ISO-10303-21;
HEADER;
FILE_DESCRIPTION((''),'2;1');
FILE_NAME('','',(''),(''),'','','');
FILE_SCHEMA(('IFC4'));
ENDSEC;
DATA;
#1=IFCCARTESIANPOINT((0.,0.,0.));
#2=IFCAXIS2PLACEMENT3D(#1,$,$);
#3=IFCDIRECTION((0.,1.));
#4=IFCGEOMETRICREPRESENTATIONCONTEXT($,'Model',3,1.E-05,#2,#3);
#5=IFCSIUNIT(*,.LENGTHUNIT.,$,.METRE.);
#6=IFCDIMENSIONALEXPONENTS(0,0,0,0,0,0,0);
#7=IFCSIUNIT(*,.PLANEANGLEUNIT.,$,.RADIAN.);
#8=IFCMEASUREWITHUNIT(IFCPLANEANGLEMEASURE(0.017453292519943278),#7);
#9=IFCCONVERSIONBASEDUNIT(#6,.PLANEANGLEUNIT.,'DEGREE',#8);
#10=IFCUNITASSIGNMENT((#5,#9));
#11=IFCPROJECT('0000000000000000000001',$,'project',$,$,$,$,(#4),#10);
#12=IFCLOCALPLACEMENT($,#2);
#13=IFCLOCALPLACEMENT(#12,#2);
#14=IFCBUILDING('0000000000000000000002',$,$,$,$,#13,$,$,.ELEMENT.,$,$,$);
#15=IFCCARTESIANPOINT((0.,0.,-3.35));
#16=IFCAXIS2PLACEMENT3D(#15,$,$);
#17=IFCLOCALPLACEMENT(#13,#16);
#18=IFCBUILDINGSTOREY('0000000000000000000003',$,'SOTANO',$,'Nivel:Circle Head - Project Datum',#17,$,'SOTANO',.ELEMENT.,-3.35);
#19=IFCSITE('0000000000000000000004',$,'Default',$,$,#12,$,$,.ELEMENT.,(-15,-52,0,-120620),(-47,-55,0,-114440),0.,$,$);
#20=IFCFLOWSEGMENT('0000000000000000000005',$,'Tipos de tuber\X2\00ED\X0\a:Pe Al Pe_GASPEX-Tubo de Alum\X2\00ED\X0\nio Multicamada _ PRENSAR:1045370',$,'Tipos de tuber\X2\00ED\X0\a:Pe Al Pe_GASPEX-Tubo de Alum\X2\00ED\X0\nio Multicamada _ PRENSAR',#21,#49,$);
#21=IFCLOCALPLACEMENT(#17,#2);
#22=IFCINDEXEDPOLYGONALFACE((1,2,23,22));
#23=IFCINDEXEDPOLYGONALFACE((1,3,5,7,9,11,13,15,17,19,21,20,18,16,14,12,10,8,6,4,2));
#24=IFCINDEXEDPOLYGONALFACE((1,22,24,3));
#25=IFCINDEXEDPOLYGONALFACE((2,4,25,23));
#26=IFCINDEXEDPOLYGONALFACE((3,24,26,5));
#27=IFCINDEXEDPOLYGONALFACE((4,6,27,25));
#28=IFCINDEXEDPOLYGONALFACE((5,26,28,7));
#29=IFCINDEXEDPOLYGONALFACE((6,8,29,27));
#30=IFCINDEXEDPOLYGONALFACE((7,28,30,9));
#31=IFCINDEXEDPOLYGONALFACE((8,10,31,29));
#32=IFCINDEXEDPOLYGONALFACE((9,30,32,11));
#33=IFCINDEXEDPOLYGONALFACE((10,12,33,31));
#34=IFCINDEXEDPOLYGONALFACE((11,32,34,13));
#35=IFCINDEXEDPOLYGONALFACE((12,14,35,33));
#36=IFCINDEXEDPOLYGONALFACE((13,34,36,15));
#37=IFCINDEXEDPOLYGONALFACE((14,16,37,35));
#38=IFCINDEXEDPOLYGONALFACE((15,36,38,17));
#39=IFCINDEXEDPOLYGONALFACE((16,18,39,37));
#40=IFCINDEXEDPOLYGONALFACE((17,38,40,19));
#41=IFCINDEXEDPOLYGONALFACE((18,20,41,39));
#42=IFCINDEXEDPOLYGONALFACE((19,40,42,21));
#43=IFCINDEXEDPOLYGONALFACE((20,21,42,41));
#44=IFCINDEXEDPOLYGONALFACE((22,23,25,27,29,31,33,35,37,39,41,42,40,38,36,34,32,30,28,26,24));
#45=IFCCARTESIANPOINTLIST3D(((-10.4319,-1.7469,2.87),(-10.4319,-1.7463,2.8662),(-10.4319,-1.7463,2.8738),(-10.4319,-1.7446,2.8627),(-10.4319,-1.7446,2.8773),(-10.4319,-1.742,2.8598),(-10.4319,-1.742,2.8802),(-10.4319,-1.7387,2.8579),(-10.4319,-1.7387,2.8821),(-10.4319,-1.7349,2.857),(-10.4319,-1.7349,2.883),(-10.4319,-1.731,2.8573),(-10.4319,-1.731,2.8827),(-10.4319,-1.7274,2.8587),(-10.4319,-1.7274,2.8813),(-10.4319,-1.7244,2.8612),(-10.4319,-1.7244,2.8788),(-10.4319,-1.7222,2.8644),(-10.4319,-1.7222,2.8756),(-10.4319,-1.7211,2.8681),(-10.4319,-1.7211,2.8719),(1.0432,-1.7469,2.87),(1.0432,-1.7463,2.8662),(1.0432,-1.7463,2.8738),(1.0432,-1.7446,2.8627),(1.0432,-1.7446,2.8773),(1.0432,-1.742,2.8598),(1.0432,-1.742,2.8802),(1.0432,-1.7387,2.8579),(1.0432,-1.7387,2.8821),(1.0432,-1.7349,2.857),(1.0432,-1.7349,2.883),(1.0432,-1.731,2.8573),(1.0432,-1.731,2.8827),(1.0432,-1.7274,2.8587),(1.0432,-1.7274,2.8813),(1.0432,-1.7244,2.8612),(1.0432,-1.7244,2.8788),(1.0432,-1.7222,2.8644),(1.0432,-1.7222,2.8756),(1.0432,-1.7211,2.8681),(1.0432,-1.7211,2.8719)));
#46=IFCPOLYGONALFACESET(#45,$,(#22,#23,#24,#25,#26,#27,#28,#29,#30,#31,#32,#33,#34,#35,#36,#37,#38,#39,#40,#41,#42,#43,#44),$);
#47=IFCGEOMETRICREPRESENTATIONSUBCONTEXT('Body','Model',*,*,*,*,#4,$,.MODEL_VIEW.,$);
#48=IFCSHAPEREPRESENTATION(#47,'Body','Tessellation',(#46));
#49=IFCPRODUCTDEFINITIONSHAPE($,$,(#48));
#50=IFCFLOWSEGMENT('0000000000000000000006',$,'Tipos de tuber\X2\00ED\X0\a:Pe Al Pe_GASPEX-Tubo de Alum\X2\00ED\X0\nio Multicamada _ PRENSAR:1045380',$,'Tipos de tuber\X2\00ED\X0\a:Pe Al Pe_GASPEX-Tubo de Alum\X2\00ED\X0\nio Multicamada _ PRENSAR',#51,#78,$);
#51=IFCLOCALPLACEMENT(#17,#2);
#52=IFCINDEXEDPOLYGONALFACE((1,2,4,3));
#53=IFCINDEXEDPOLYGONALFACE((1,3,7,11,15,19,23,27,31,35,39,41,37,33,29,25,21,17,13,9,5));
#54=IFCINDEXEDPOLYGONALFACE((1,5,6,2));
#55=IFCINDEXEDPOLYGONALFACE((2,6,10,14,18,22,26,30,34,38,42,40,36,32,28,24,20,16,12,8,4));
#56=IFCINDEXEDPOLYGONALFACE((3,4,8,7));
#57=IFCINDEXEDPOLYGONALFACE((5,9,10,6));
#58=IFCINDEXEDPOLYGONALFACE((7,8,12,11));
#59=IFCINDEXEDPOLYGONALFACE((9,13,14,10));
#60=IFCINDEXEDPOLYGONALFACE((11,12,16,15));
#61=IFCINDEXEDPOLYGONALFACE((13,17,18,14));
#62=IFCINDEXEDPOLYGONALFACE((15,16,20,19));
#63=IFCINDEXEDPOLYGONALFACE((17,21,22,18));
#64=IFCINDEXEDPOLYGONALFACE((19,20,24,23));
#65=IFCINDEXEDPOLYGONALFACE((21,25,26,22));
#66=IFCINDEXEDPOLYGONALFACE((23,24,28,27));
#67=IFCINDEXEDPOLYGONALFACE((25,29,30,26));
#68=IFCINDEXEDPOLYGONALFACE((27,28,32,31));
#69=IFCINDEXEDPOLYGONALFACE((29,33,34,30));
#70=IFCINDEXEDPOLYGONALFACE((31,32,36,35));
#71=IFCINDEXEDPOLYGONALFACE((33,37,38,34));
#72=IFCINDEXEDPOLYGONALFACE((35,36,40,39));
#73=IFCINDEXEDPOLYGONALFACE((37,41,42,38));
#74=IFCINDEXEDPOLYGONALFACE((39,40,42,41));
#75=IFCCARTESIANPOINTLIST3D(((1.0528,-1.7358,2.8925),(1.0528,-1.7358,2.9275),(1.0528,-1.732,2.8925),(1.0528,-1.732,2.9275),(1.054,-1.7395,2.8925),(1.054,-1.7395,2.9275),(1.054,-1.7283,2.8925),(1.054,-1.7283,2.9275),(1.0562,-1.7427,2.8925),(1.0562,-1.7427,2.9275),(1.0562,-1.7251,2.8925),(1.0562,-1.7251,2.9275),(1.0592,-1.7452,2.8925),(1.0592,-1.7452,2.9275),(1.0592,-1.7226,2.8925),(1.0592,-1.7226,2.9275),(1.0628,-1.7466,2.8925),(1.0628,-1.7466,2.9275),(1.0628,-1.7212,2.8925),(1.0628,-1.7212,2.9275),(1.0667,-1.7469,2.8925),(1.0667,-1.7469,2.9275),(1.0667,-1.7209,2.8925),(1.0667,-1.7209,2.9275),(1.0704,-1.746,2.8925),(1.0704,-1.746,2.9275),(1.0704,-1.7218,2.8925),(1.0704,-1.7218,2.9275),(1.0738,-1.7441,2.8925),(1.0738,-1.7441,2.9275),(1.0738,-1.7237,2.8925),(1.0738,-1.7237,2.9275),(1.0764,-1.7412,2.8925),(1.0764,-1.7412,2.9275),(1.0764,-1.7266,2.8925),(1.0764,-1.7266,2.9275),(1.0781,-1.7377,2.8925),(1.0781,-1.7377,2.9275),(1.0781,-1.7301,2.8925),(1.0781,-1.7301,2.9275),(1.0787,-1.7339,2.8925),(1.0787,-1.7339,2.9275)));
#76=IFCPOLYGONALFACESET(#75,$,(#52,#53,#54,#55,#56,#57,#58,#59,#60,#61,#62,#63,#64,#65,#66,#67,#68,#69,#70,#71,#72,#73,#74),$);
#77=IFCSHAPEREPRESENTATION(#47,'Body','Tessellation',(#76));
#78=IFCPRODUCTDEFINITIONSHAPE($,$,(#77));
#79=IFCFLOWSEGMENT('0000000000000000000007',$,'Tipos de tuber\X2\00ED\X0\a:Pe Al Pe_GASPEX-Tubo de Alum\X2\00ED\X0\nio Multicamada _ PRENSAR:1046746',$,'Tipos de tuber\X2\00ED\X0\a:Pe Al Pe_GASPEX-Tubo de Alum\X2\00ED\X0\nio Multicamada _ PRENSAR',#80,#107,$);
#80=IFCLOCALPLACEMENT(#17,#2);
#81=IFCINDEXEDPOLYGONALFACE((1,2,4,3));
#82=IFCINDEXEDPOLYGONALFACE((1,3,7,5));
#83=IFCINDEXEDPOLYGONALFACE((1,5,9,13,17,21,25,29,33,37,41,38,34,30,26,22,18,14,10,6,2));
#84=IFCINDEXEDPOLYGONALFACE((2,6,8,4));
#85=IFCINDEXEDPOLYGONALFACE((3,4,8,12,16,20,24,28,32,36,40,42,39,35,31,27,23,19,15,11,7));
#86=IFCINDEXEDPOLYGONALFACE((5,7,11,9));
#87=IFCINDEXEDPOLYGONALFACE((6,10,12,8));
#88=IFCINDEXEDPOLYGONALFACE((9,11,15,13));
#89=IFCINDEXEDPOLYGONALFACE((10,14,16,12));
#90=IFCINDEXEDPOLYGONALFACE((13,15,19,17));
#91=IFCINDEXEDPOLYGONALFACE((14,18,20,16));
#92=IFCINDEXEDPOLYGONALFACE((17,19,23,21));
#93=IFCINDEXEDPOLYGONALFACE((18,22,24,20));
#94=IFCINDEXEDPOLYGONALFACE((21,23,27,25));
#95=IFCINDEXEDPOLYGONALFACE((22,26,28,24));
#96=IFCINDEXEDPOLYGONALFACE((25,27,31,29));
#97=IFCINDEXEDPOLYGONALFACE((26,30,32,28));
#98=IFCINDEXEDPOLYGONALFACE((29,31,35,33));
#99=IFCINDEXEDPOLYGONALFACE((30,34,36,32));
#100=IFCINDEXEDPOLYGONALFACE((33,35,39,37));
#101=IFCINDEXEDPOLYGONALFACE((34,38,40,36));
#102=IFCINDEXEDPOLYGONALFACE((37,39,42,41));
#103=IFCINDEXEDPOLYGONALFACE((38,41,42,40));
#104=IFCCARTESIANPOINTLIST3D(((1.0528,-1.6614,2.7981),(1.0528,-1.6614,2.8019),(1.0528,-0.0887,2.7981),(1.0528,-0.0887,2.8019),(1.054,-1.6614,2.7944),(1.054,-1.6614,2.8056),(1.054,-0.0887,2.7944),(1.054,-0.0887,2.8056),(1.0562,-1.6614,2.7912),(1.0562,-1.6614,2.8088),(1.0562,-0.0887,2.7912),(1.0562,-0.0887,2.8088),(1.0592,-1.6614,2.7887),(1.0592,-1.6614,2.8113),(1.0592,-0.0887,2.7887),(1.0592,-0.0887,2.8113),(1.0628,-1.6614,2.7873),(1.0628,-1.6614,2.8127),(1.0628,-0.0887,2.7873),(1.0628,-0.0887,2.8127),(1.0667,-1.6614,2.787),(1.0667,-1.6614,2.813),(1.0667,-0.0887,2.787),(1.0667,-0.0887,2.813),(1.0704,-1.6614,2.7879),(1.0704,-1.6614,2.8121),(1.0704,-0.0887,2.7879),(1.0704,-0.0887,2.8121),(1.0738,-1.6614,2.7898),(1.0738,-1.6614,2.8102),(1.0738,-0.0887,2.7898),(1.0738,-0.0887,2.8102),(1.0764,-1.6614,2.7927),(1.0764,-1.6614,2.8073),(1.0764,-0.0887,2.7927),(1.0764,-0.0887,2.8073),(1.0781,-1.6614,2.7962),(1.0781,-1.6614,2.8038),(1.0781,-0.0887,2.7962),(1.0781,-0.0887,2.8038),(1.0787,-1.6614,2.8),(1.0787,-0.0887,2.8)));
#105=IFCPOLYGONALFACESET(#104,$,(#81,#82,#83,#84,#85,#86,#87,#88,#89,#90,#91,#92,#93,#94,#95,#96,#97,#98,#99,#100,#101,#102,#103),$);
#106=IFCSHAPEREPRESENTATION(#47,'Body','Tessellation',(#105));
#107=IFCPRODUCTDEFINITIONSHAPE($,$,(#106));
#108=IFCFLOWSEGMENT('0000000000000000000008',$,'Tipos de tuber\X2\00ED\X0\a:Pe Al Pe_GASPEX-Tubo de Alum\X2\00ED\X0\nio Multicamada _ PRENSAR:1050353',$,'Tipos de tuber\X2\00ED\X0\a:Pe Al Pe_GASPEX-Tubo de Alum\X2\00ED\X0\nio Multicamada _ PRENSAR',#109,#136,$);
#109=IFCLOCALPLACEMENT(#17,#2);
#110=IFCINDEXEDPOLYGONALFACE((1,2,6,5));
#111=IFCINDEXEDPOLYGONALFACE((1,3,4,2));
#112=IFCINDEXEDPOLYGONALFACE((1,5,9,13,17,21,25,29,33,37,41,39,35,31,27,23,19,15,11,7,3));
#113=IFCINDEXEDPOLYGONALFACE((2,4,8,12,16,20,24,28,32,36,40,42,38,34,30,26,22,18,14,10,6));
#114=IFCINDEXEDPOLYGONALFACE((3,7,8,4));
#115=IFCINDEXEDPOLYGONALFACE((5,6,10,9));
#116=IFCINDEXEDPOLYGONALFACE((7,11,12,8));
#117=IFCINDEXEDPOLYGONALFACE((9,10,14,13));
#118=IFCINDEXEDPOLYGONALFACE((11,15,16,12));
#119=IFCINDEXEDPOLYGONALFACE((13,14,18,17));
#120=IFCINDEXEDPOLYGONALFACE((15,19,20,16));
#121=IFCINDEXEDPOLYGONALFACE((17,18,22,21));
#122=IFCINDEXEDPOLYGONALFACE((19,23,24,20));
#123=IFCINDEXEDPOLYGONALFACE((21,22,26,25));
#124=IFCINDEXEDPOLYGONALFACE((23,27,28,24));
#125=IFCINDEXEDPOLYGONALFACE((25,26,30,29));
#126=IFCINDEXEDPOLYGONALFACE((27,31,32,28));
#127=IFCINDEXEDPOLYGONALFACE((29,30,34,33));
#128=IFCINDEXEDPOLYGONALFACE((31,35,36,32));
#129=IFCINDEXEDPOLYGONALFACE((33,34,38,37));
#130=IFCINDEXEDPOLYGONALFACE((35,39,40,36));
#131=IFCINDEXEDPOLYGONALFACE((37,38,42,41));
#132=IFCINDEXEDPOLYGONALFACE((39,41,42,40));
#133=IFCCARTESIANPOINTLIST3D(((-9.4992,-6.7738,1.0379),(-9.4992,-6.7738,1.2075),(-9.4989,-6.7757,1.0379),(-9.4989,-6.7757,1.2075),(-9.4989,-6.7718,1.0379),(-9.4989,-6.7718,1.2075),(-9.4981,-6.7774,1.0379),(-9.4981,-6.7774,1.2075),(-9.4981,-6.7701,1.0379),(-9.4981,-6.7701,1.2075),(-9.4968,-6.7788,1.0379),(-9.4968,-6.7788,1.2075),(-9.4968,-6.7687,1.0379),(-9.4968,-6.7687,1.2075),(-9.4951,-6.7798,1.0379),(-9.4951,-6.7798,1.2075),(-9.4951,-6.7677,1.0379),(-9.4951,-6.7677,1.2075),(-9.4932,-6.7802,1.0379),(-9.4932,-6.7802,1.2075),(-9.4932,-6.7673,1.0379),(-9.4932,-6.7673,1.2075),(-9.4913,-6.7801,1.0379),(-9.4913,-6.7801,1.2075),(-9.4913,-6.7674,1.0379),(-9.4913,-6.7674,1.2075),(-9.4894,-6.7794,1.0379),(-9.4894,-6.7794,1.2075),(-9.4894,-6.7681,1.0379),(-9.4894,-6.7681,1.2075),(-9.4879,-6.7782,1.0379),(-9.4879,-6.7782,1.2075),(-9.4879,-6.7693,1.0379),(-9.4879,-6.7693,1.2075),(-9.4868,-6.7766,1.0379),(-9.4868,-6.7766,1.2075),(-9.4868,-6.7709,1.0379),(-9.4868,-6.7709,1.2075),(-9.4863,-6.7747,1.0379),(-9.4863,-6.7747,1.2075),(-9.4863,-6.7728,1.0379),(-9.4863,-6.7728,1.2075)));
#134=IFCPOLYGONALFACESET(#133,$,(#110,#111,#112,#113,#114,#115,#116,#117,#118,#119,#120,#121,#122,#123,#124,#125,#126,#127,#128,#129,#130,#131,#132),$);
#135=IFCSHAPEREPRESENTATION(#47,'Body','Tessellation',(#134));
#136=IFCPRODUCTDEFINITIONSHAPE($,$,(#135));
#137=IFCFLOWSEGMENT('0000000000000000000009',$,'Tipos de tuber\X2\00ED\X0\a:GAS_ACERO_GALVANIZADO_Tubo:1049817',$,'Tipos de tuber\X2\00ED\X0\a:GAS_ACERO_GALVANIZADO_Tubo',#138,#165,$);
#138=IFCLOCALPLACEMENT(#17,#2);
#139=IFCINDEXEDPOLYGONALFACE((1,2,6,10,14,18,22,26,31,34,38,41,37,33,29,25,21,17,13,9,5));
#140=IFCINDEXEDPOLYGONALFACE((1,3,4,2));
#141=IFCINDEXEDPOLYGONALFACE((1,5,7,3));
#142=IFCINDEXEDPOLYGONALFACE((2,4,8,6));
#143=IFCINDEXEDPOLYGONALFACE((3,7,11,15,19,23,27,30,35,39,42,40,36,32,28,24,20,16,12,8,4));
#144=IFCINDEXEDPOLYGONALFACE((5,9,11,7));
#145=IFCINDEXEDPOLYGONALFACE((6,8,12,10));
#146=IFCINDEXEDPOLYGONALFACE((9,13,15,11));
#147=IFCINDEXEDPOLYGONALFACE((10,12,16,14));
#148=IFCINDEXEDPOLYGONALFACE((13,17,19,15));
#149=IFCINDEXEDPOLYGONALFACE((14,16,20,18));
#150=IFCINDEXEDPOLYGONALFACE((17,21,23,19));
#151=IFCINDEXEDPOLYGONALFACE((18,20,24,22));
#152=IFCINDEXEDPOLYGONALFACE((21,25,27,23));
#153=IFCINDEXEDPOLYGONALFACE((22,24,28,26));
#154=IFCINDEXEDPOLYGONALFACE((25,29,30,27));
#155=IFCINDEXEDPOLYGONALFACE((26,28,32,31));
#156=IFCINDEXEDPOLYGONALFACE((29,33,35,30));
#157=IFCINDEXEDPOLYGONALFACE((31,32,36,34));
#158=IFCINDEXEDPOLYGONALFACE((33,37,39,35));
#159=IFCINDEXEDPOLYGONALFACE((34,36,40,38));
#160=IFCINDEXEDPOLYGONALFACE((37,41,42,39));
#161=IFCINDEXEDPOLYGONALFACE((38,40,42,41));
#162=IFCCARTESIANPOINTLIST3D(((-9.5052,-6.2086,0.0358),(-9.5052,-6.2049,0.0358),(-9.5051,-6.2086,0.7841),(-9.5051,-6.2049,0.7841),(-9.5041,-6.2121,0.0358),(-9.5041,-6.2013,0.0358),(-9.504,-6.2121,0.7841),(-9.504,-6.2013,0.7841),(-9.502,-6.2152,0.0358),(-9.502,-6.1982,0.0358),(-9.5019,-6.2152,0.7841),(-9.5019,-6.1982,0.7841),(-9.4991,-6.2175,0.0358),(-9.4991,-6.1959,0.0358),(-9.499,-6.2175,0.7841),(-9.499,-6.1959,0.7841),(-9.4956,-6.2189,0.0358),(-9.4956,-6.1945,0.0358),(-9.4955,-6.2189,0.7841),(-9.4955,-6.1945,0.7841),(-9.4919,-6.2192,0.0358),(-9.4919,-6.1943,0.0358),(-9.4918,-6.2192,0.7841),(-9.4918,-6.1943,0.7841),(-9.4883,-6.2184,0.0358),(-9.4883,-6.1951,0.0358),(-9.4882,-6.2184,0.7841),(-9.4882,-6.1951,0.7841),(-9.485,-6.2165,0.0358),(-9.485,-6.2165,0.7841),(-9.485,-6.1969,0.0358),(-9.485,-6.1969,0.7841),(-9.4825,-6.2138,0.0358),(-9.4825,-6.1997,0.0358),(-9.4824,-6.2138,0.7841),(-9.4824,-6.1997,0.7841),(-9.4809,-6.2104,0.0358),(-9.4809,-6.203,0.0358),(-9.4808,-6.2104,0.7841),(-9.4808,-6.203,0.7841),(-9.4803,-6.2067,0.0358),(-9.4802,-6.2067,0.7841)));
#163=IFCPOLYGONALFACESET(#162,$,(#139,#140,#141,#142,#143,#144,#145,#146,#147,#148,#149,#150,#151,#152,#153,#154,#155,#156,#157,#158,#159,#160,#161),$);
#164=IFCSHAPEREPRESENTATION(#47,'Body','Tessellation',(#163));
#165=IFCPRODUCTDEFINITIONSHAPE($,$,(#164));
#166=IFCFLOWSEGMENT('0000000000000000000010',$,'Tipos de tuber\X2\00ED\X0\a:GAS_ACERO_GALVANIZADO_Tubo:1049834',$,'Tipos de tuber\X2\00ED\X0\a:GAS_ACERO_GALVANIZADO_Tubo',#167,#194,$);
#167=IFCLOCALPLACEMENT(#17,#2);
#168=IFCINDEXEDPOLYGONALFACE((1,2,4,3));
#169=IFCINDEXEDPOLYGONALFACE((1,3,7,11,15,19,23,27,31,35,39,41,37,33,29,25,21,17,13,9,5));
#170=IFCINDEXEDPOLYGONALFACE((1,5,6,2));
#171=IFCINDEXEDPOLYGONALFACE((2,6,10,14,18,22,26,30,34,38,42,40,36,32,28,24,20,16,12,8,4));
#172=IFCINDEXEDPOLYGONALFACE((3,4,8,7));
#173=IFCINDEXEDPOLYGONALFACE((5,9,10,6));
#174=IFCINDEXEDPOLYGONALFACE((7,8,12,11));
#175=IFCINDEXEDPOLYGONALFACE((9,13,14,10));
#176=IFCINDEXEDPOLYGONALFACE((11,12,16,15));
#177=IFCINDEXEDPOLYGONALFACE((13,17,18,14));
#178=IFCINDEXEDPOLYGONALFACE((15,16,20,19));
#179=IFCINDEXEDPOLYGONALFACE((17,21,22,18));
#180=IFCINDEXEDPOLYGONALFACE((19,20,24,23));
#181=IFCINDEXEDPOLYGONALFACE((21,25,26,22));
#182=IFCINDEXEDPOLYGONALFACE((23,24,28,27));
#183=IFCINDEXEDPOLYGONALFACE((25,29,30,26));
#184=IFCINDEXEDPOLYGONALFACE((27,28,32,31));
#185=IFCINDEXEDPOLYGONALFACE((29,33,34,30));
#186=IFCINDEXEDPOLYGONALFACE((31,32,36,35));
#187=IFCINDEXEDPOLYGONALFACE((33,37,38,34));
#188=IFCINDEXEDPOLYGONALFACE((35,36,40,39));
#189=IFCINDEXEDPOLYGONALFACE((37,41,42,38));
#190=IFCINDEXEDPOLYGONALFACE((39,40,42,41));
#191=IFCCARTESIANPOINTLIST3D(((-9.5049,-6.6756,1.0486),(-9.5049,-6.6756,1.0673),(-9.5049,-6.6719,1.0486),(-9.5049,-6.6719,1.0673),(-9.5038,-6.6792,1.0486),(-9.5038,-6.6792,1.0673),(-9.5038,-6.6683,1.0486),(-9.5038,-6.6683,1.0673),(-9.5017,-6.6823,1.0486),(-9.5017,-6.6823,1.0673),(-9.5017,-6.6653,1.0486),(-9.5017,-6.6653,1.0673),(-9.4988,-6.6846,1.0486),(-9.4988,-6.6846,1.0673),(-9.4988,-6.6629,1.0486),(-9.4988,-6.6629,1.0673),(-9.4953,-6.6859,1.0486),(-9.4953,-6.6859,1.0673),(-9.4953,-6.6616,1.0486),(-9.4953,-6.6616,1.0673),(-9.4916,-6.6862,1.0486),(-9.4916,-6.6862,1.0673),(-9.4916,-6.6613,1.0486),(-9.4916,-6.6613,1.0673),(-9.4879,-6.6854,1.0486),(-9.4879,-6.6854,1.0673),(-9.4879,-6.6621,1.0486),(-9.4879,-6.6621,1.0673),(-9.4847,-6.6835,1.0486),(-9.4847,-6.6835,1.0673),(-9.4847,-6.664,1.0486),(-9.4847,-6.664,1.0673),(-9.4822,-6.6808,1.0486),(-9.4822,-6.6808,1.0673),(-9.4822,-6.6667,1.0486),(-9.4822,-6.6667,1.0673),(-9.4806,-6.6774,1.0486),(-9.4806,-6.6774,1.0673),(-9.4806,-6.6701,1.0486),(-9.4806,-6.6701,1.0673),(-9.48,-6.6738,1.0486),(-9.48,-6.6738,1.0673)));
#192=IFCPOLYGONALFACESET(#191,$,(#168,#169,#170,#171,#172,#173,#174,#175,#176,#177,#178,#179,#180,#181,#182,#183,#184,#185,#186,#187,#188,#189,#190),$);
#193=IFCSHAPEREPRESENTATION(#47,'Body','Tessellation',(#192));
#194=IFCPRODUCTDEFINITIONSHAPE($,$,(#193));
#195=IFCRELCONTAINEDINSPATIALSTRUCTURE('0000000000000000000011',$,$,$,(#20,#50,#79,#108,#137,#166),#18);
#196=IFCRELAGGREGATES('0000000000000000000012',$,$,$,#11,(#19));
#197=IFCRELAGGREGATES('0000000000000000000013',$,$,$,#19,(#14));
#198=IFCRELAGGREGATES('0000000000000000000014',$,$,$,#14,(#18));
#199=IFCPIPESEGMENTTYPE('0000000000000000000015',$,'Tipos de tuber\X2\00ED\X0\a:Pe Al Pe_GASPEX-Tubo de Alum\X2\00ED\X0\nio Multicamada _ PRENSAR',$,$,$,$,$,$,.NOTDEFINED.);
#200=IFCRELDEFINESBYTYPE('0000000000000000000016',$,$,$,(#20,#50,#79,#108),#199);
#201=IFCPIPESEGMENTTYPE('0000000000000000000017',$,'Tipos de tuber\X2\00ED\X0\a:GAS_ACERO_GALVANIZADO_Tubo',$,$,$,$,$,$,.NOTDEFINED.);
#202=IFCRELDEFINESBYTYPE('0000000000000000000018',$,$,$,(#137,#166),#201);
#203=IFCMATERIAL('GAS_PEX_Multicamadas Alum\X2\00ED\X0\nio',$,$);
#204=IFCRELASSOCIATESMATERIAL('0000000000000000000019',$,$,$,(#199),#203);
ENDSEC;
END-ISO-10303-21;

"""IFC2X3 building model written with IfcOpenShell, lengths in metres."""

from ifc_helpers import new_model, entity, si_unit, converted_unit, direction, frame, frame_2d, origin, origin_2d_with_axis, place, context, subcontext, project, spatial, circle, extrude, material, type_object, element, save


model = new_model("IFC2X3")

# Units and contexts
model_context = context("Model", 3, precision=1e-05, world=origin(), true_north=direction((0.0, 1.0)))
body_context = subcontext(model_context, "Body", "Model", "MODEL_VIEW")
ifc_project = project(units=[si_unit("LENGTHUNIT", "METRE"), converted_unit("PLANEANGLEUNIT", "DEGREE", entity("IfcPlaneAngleMeasure", 0.017453292519943278), si_unit("PLANEANGLEUNIT", "RADIAN"), dimensions=[0, 0, 0, 0, 0, 0, 0])], contexts=[model_context])

# Site, building, storey
site_placement = place(None, origin())
site = spatial("IfcSite", under=ifc_project, at=site_placement, Name="Default", CompositionType="ELEMENT", RefLatitude=(-15, -52, 0, -120620), RefLongitude=(-47, -55, 0, -114440), RefElevation=0.0)
building_placement = place(site_placement, origin())
building = spatial("IfcBuilding", under=site, at=building_placement, CompositionType="ELEMENT")
storey_placement = place(building_placement, frame((0.0, 0.0, -3.35)))
storey = spatial("IfcBuildingStorey", under=building, at=storey_placement, Name="SOTANO", ObjectType="Nivel:Circle Head - Project Datum", LongName="SOTANO", CompositionType="ELEMENT", Elevation=-3.35)

# Flow segments
ifc_material = material(Name="GAS_PEX_Multicamadas Alumínio")
pipe_segment_type_1 = type_object("IfcPipeSegmentType", Name="Tipos de tubería:Pe Al Pe_GASPEX-Tubo de Alumínio Multicamada _ PRENSAR", PredefinedType="NOTDEFINED", material=ifc_material)
flow_segment_1_placement = place(storey_placement, origin())
element("IfcFlowSegment", 1, at=flow_segment_1_placement, inside=storey, type_object=pipe_segment_type_1, Name="Tipos de tubería:Pe Al Pe_GASPEX-Tubo de Alumínio Multicamada _ PRENSAR:1045370", ObjectType="Tipos de tubería:Pe Al Pe_GASPEX-Tubo de Alumínio Multicamada _ PRENSAR", context=body_context, shape_type="SweptSolid", body=[
    extrude(circle(Radius=0.013, at=origin_2d_with_axis()), frame((-10.4319, -1.7339, 2.87), z_axis=(1.0, 0.0, 0.0), x_axis=(0.0, -1.0, 0.0)), (0.0, 0.0, 1.0), 11.4751),
])
flow_segment_2_placement = place(storey_placement, origin())
element("IfcFlowSegment", 2, at=flow_segment_2_placement, inside=storey, type_object=pipe_segment_type_1, Name="Tipos de tubería:Pe Al Pe_GASPEX-Tubo de Alumínio Multicamada _ PRENSAR:1045380", ObjectType="Tipos de tubería:Pe Al Pe_GASPEX-Tubo de Alumínio Multicamada _ PRENSAR", context=body_context, shape_type="SweptSolid", body=[
    extrude(circle(Radius=0.013, at=origin_2d_with_axis()), frame((1.0657, -1.7339, 2.8925)), (0.0, 0.0, 1.0), 0.035),
])
flow_segment_3_placement = place(storey_placement, origin())
element("IfcFlowSegment", 3, at=flow_segment_3_placement, inside=storey, type_object=pipe_segment_type_1, Name="Tipos de tubería:Pe Al Pe_GASPEX-Tubo de Alumínio Multicamada _ PRENSAR:1046746", ObjectType="Tipos de tubería:Pe Al Pe_GASPEX-Tubo de Alumínio Multicamada _ PRENSAR", context=body_context, shape_type="SweptSolid", body=[
    extrude(circle(Radius=0.013, at=origin_2d_with_axis()), frame((1.0657, -1.6614, 2.8), z_axis=(0.0, 1.0, 0.0), x_axis=(1.0, 0.0, 0.0)), (0.0, 0.0, 1.0), 1.5727),
])
flow_segment_4_placement = place(storey_placement, origin())
element("IfcFlowSegment", 4, at=flow_segment_4_placement, inside=storey, type_object=pipe_segment_type_1, Name="Tipos de tubería:Pe Al Pe_GASPEX-Tubo de Alumínio Multicamada _ PRENSAR:1050353", ObjectType="Tipos de tubería:Pe Al Pe_GASPEX-Tubo de Alumínio Multicamada _ PRENSAR", context=body_context, shape_type="SweptSolid", body=[
    extrude(circle(Radius=0.0065, at=frame_2d((0.0, 0.0), x_axis=(1.0, 0.0))), frame((-9.4927, -6.7738, 1.0379), z_axis=(0.0, 0.0, 1.0), x_axis=(-1.0, 0.0, 0.0)), (0.0, 0.0, 1.0), 0.1696),
])
pipe_segment_type_2 = type_object("IfcPipeSegmentType", Name="Tipos de tubería:GAS_ACERO_GALVANIZADO_Tubo", PredefinedType="NOTDEFINED")
flow_segment_5_placement = place(storey_placement, origin())
element("IfcFlowSegment", 5, at=flow_segment_5_placement, inside=storey, type_object=pipe_segment_type_2, Name="Tipos de tubería:GAS_ACERO_GALVANIZADO_Tubo:1049817", ObjectType="Tipos de tubería:GAS_ACERO_GALVANIZADO_Tubo", context=body_context, shape_type="SweptSolid", body=[
    extrude(circle(Radius=0.0125, at=frame_2d((0.0, 0.0), x_axis=(1.0, 0.0))), frame((-9.4928, -6.2067, 0.0358), z_axis=(0.000106, 0.0, 1.0), x_axis=(1.0, 0.0, -0.000106)), (0.0, 0.0, 1.0), 0.7483),
])
flow_segment_6_placement = place(storey_placement, origin())
element("IfcFlowSegment", 6, at=flow_segment_6_placement, inside=storey, type_object=pipe_segment_type_2, Name="Tipos de tubería:GAS_ACERO_GALVANIZADO_Tubo:1049834", ObjectType="Tipos de tubería:GAS_ACERO_GALVANIZADO_Tubo", context=body_context, shape_type="SweptSolid", body=[
    extrude(circle(Radius=0.0125, at=origin_2d_with_axis()), frame((-9.4925, -6.6738, 1.0486)), (0.0, 0.0, 1.0), 0.0187),
])

save(model, "model.ifc")
